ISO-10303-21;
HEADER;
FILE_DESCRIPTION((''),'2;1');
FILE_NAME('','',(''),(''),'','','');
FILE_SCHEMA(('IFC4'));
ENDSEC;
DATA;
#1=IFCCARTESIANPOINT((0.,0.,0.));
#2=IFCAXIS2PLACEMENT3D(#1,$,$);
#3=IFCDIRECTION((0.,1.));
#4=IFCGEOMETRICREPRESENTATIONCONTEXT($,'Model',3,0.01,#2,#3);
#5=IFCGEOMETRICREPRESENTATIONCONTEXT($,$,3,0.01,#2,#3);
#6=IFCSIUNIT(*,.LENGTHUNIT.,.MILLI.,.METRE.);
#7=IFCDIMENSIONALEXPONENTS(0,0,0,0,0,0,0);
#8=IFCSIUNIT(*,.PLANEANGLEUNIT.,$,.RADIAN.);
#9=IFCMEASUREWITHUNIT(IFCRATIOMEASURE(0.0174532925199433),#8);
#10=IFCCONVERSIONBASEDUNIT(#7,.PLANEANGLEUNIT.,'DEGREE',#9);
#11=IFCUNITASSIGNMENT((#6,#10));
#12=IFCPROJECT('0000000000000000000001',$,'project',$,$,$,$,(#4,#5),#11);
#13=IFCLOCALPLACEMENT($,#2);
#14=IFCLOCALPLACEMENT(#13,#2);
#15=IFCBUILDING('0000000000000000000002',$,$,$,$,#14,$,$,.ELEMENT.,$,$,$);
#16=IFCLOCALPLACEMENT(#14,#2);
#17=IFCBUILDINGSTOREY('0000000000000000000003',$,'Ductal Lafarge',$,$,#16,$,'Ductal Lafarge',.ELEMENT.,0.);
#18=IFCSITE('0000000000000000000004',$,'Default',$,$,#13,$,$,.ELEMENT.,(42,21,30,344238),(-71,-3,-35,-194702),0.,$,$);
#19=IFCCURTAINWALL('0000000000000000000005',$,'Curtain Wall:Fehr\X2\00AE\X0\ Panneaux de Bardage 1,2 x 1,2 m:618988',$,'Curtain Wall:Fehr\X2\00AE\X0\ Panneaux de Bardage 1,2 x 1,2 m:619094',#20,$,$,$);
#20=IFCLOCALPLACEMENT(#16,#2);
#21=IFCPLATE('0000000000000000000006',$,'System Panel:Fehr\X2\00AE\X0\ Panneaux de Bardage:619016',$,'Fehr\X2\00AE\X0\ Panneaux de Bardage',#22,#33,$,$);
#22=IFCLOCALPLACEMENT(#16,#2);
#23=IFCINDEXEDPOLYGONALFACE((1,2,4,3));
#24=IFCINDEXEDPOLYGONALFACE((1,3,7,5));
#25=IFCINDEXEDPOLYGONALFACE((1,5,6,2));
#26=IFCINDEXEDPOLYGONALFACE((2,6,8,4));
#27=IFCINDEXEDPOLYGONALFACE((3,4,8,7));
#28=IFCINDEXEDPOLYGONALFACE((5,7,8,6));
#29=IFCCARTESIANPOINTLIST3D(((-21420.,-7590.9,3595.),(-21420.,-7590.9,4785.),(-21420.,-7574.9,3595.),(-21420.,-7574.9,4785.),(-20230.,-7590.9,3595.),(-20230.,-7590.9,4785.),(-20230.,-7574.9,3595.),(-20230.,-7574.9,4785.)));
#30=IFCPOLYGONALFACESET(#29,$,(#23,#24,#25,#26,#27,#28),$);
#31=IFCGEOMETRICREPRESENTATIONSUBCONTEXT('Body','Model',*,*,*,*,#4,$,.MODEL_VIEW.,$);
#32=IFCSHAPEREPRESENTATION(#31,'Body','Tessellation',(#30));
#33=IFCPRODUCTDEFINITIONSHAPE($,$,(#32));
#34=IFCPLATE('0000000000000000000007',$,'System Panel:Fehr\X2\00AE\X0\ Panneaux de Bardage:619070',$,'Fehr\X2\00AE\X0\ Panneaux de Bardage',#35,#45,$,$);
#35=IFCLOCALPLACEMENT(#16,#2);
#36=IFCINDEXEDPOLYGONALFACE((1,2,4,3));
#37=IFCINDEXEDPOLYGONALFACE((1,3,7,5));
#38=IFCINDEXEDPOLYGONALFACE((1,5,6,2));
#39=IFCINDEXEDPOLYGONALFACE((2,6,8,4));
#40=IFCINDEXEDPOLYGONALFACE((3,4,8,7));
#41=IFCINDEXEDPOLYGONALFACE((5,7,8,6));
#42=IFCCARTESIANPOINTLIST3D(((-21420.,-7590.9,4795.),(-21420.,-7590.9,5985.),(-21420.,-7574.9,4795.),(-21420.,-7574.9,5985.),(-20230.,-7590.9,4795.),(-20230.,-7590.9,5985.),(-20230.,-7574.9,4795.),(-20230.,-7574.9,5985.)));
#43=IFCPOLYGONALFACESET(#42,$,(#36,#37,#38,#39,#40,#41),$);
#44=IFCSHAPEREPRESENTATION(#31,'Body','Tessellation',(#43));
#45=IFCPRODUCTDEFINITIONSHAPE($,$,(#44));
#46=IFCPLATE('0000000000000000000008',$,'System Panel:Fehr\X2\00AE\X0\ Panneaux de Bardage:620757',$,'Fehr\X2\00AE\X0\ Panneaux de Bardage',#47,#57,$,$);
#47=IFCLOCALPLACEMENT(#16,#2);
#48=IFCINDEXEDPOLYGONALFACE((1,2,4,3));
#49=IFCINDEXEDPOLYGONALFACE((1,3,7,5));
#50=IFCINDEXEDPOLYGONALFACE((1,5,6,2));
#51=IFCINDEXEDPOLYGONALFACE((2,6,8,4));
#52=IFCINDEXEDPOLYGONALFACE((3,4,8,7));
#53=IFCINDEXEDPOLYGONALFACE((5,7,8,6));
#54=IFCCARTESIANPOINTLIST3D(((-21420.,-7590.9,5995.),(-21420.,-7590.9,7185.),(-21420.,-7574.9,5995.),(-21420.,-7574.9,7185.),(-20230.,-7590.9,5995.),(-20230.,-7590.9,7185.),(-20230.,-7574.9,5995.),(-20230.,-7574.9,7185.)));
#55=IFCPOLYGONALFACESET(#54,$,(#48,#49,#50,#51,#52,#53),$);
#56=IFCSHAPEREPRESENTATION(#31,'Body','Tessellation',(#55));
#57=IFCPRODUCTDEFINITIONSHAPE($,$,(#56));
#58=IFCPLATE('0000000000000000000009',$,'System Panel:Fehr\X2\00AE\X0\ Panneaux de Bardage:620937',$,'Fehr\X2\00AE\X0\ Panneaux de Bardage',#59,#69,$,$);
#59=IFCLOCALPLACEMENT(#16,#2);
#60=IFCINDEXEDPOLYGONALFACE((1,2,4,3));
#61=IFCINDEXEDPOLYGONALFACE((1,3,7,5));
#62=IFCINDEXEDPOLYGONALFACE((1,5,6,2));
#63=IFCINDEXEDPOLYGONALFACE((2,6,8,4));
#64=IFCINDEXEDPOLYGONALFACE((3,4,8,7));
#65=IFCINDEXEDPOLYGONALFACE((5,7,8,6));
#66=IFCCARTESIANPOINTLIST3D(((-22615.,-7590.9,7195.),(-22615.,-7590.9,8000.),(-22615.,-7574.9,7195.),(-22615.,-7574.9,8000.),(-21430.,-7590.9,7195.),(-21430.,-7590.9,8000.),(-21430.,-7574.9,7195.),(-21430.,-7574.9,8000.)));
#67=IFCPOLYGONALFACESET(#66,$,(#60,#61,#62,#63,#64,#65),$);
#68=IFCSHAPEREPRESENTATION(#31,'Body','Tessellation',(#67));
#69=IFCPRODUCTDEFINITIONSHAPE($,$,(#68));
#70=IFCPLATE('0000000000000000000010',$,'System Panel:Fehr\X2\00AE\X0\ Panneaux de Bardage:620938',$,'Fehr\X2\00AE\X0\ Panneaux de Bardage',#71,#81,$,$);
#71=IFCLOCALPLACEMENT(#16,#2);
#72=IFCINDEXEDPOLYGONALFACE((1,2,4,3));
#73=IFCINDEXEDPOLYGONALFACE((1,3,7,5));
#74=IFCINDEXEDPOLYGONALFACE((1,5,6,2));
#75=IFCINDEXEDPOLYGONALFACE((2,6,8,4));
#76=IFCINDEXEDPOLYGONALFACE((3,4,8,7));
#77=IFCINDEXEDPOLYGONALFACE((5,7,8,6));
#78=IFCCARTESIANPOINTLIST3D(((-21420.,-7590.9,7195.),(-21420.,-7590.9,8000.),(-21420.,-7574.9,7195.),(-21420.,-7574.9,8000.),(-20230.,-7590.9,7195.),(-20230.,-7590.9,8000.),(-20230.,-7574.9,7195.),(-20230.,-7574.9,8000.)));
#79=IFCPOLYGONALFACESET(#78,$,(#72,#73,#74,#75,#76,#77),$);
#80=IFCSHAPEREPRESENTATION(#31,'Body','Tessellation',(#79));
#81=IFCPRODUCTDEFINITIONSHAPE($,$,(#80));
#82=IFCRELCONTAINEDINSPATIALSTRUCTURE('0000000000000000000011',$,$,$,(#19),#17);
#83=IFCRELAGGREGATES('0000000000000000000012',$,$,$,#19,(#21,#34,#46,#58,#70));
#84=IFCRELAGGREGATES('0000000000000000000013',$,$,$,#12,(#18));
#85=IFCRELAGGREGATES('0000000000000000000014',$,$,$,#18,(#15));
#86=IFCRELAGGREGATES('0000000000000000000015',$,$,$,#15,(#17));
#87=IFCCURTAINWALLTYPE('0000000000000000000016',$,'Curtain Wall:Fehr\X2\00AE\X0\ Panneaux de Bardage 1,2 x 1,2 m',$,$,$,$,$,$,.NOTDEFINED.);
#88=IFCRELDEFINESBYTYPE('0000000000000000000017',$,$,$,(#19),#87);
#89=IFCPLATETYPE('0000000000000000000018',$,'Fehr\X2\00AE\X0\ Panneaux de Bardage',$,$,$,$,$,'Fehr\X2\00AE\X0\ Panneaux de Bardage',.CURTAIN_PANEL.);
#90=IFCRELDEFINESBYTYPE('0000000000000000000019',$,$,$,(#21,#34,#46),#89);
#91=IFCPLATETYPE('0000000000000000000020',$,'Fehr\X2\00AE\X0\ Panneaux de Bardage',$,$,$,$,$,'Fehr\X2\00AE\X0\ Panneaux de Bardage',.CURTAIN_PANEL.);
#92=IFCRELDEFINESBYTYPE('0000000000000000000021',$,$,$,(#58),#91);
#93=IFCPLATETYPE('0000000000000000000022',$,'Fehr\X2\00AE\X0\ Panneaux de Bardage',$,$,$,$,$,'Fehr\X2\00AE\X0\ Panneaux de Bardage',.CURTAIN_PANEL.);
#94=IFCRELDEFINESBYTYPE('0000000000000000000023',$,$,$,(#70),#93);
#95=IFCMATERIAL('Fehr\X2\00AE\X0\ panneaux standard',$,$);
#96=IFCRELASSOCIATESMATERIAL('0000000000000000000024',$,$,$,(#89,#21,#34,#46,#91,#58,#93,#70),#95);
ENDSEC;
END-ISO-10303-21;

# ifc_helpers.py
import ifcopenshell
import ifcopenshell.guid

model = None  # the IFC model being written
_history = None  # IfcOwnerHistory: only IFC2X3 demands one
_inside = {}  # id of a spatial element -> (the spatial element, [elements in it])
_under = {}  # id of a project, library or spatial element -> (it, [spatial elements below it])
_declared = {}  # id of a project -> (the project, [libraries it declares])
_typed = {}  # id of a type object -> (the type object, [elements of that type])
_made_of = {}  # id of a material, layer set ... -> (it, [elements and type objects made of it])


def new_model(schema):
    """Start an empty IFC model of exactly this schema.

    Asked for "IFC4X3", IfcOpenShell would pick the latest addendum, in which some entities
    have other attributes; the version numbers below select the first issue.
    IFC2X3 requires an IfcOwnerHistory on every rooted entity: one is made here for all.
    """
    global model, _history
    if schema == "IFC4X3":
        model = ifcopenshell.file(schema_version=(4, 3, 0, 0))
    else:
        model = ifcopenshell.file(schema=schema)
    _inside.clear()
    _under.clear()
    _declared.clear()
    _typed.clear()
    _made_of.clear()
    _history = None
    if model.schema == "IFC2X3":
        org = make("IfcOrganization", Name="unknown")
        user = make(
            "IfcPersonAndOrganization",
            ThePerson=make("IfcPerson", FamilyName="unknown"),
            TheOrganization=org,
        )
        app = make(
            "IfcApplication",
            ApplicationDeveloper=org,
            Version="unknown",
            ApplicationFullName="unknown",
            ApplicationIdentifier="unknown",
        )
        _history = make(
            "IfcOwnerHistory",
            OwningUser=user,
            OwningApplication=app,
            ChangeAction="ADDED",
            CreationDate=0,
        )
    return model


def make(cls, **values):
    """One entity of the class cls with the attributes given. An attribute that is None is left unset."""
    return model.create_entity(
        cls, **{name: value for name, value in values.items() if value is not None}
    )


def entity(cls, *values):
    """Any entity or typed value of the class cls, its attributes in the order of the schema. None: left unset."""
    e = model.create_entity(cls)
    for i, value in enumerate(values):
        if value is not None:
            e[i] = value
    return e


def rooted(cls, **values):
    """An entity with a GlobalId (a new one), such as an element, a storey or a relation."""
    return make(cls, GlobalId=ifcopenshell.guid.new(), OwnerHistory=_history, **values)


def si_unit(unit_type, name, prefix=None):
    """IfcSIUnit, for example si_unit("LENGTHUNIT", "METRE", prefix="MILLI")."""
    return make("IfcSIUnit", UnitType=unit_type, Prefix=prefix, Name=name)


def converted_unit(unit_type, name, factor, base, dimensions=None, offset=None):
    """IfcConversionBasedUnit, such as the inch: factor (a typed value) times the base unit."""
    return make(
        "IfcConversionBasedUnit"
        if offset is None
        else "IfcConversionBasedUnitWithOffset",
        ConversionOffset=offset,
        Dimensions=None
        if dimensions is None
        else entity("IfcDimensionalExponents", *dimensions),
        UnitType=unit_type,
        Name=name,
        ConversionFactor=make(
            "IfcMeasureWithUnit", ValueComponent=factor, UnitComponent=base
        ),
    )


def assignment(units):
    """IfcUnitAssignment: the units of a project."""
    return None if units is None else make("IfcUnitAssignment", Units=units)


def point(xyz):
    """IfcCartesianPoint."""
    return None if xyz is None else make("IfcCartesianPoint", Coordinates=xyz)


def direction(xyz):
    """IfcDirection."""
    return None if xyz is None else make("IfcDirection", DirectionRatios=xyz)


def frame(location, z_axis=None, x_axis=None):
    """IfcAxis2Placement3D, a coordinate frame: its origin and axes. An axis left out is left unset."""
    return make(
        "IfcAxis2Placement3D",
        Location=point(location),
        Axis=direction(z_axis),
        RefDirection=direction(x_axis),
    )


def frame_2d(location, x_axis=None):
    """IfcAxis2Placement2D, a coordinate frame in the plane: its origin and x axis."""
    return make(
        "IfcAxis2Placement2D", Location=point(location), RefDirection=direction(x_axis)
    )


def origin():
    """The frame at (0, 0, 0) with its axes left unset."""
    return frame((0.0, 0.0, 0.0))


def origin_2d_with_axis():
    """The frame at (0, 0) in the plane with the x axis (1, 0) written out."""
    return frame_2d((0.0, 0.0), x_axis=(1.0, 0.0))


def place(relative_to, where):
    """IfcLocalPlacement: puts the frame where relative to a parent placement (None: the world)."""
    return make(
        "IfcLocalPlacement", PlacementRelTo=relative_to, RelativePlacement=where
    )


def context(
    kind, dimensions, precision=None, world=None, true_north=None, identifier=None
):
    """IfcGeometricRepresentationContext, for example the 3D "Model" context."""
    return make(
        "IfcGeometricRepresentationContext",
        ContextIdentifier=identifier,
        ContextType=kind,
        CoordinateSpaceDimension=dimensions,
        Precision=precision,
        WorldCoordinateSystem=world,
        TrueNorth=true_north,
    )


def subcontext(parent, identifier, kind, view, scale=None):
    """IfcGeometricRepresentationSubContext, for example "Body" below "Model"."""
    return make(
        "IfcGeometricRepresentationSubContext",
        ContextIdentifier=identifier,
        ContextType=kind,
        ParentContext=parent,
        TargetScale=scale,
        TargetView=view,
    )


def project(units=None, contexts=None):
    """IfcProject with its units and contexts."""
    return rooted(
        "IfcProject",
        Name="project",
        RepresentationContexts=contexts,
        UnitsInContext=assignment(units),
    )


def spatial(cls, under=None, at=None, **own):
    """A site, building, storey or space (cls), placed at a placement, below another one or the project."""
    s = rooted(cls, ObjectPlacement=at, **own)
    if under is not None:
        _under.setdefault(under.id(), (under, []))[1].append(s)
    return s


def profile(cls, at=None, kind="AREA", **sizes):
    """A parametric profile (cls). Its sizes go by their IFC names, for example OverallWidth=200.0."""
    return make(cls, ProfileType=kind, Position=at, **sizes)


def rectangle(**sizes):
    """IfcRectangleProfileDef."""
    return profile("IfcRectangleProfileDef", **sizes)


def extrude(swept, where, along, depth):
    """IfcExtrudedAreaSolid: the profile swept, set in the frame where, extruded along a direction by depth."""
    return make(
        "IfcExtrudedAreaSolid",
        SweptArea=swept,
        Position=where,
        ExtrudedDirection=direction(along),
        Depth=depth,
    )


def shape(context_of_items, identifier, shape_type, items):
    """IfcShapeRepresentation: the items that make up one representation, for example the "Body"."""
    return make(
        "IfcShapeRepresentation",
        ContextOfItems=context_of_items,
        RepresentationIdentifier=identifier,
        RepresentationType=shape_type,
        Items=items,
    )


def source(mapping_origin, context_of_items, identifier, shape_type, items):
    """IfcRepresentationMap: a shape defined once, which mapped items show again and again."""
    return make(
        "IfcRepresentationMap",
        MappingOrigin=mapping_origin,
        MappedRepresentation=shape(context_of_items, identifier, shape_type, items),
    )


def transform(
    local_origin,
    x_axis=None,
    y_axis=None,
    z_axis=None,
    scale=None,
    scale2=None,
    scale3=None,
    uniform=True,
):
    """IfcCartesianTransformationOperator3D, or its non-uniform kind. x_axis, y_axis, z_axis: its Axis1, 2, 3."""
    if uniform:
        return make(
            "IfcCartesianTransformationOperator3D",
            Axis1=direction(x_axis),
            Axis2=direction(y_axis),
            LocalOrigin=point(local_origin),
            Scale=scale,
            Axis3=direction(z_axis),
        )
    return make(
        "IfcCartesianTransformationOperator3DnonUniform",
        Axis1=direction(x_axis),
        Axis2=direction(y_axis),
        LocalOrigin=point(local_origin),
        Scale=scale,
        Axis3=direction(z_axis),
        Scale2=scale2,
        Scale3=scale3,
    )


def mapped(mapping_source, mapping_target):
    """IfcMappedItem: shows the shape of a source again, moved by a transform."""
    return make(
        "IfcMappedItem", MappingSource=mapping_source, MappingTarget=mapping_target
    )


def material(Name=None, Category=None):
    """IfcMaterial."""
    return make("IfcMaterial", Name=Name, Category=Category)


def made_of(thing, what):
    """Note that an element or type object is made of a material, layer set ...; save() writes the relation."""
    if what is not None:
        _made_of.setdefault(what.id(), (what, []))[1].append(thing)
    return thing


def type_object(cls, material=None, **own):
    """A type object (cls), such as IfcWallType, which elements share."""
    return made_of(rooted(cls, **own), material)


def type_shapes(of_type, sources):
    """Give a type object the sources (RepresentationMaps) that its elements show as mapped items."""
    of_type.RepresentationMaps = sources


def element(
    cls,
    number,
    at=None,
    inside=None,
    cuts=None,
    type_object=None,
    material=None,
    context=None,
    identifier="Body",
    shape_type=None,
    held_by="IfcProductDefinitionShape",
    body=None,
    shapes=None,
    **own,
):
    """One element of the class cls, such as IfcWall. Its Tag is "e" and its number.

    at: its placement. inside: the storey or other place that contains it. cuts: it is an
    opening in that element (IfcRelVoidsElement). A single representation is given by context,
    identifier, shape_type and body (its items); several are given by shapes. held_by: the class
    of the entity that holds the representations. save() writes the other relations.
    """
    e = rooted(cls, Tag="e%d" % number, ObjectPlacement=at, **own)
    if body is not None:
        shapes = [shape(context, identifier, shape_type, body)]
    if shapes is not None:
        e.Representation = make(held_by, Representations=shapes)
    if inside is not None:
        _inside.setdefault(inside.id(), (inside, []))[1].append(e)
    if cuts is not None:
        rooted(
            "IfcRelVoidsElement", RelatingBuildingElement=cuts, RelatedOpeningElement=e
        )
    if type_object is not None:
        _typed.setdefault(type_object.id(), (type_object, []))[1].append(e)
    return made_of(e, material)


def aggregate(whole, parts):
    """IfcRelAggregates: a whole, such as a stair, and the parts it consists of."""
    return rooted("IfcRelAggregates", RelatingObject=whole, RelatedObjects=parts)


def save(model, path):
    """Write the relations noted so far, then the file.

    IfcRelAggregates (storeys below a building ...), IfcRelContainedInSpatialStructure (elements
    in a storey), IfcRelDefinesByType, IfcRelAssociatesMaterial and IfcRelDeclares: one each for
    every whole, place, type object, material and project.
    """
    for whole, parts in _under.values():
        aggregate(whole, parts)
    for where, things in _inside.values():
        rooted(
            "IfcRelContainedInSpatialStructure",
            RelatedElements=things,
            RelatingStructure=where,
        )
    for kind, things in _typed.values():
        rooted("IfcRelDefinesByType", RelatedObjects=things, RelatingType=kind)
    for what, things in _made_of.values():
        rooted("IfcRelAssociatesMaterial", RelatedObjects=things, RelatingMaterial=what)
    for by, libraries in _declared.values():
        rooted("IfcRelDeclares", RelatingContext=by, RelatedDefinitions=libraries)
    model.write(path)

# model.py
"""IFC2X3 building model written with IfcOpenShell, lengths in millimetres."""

from ifc_helpers import new_model, entity, si_unit, converted_unit, direction, frame, origin, origin_2d_with_axis, place, context, subcontext, project, spatial, rectangle, extrude, source, transform, mapped, material, type_object, type_shapes, element, aggregate, save


model = new_model("IFC2X3")

# Units and contexts
model_context = context("Model", 3, precision=0.01, world=origin(), true_north=direction((0.0, 1.0)))
context_of_model = context(None, 3, precision=0.01, world=origin(), true_north=direction((0.0, 1.0)))
body_context = subcontext(model_context, "Body", "Model", "MODEL_VIEW")
ifc_project = project(units=[si_unit("LENGTHUNIT", "METRE", prefix="MILLI"), converted_unit("PLANEANGLEUNIT", "DEGREE", entity("IfcRatioMeasure", 0.0174532925199433), si_unit("PLANEANGLEUNIT", "RADIAN"), dimensions=[0, 0, 0, 0, 0, 0, 0])], contexts=[model_context, context_of_model])

# Site, building, storey
site_placement = place(None, origin())
site = spatial("IfcSite", under=ifc_project, at=site_placement, Name="Default", CompositionType="ELEMENT", RefLatitude=(42, 21, 30, 344238), RefLongitude=(-71, -3, -35, -194702), RefElevation=0.0)
building_placement = place(site_placement, origin())
building = spatial("IfcBuilding", under=site, at=building_placement, CompositionType="ELEMENT")
storey_placement = place(building_placement, origin())
storey = spatial("IfcBuildingStorey", under=building, at=storey_placement, Name="Ductal Lafarge", LongName="Ductal Lafarge", CompositionType="ELEMENT", Elevation=0.0)

# Curtain wall, plates
curtain_wall_type = type_object("IfcCurtainWallType", Name="Curtain Wall:Fehr® Panneaux de Bardage 1,2 x 1,2 m", PredefinedType="NOTDEFINED")
curtain_wall_placement = place(storey_placement, origin())
curtain_wall = element("IfcCurtainWall", 1, at=curtain_wall_placement, inside=storey, type_object=curtain_wall_type, Name="Curtain Wall:Fehr® Panneaux de Bardage 1,2 x 1,2 m:618988", ObjectType="Curtain Wall:Fehr® Panneaux de Bardage 1,2 x 1,2 m:619094")
ifc_material_1 = material(Name="Fehr® panneaux standard")
plate_type_1 = type_object("IfcPlateType", Name="Fehr® Panneaux de Bardage", ElementType="Fehr® Panneaux de Bardage", PredefinedType="CURTAIN_PANEL", material=ifc_material_1)
shared_shape_1 = source(origin(), body_context, "Body", "SweptSolid", [
    extrude(rectangle(XDim=16.0, YDim=1190.0, at=origin_2d_with_axis()), frame((0.0, 0.0, 0.0), z_axis=(0.0, 0.0, 1.0), x_axis=(0.0, 1.0, 0.0)), (0.0, 0.0, 1.0), 1190.0),
])
type_shapes(plate_type_1, [shared_shape_1])
plate_1_placement = place(curtain_wall_placement, frame((-20825.0, -7582.9, 3595.0)))
plate_1 = element("IfcPlate", 2, at=plate_1_placement, type_object=plate_type_1, material=ifc_material_1, Name="System Panel:Fehr® Panneaux de Bardage:619016", ObjectType="Fehr® Panneaux de Bardage", context=body_context, shape_type="MappedRepresentation", body=[
    mapped(shared_shape_1, transform((0.0, 0.0, 0.0), scale=1.0)),
])
plate_2_placement = place(curtain_wall_placement, frame((-20825.0, -7582.9, 4795.0)))
plate_2 = element("IfcPlate", 3, at=plate_2_placement, type_object=plate_type_1, material=ifc_material_1, Name="System Panel:Fehr® Panneaux de Bardage:619070", ObjectType="Fehr® Panneaux de Bardage", context=body_context, shape_type="MappedRepresentation", body=[
    mapped(shared_shape_1, transform((0.0, 0.0, 0.0), scale=1.0)),
])
plate_3_placement = place(curtain_wall_placement, frame((-20825.0, -7582.9, 5995.0)))
plate_3 = element("IfcPlate", 4, at=plate_3_placement, type_object=plate_type_1, material=ifc_material_1, Name="System Panel:Fehr® Panneaux de Bardage:620757", ObjectType="Fehr® Panneaux de Bardage", context=body_context, shape_type="MappedRepresentation", body=[
    mapped(shared_shape_1, transform((0.0, 0.0, 0.0), scale=1.0)),
])
plate_type_2 = type_object("IfcPlateType", Name="Fehr® Panneaux de Bardage", ElementType="Fehr® Panneaux de Bardage", PredefinedType="CURTAIN_PANEL", material=ifc_material_1)
shared_shape_2 = source(origin(), body_context, "Body", "SweptSolid", [
    extrude(rectangle(XDim=16.0, YDim=1185.0, at=origin_2d_with_axis()), frame((0.0, 0.0, 0.0), z_axis=(0.0, 0.0, 1.0), x_axis=(0.0, 1.0, 0.0)), (0.0, 0.0, 1.0), 805.0),
])
type_shapes(plate_type_2, [shared_shape_2])
plate_4_placement = place(curtain_wall_placement, frame((-22022.5, -7582.9, 7195.0)))
plate_4 = element("IfcPlate", 5, at=plate_4_placement, type_object=plate_type_2, material=ifc_material_1, Name="System Panel:Fehr® Panneaux de Bardage:620937", ObjectType="Fehr® Panneaux de Bardage", context=body_context, shape_type="MappedRepresentation", body=[
    mapped(shared_shape_2, transform((0.0, 0.0, 0.0), scale=1.0)),
])
plate_type_3 = type_object("IfcPlateType", Name="Fehr® Panneaux de Bardage", ElementType="Fehr® Panneaux de Bardage", PredefinedType="CURTAIN_PANEL", material=ifc_material_1)
shared_shape_3 = source(origin(), body_context, "Body", "SweptSolid", [
    extrude(rectangle(XDim=16.0, YDim=1190.0, at=origin_2d_with_axis()), frame((0.0, 0.0, 0.0), z_axis=(0.0, 0.0, 1.0), x_axis=(0.0, 1.0, 0.0)), (0.0, 0.0, 1.0), 805.0),
])
type_shapes(plate_type_3, [shared_shape_3])
plate_5_placement = place(curtain_wall_placement, frame((-20825.0, -7582.9, 7195.0)))
plate_5 = element("IfcPlate", 6, at=plate_5_placement, type_object=plate_type_3, material=ifc_material_1, Name="System Panel:Fehr® Panneaux de Bardage:620938", ObjectType="Fehr® Panneaux de Bardage", context=body_context, shape_type="MappedRepresentation", body=[
    mapped(shared_shape_3, transform((0.0, 0.0, 0.0), scale=1.0)),
])
aggregate(curtain_wall, [plate_1, plate_2, plate_3, plate_4, plate_5])

save(model, "model.ifc")
